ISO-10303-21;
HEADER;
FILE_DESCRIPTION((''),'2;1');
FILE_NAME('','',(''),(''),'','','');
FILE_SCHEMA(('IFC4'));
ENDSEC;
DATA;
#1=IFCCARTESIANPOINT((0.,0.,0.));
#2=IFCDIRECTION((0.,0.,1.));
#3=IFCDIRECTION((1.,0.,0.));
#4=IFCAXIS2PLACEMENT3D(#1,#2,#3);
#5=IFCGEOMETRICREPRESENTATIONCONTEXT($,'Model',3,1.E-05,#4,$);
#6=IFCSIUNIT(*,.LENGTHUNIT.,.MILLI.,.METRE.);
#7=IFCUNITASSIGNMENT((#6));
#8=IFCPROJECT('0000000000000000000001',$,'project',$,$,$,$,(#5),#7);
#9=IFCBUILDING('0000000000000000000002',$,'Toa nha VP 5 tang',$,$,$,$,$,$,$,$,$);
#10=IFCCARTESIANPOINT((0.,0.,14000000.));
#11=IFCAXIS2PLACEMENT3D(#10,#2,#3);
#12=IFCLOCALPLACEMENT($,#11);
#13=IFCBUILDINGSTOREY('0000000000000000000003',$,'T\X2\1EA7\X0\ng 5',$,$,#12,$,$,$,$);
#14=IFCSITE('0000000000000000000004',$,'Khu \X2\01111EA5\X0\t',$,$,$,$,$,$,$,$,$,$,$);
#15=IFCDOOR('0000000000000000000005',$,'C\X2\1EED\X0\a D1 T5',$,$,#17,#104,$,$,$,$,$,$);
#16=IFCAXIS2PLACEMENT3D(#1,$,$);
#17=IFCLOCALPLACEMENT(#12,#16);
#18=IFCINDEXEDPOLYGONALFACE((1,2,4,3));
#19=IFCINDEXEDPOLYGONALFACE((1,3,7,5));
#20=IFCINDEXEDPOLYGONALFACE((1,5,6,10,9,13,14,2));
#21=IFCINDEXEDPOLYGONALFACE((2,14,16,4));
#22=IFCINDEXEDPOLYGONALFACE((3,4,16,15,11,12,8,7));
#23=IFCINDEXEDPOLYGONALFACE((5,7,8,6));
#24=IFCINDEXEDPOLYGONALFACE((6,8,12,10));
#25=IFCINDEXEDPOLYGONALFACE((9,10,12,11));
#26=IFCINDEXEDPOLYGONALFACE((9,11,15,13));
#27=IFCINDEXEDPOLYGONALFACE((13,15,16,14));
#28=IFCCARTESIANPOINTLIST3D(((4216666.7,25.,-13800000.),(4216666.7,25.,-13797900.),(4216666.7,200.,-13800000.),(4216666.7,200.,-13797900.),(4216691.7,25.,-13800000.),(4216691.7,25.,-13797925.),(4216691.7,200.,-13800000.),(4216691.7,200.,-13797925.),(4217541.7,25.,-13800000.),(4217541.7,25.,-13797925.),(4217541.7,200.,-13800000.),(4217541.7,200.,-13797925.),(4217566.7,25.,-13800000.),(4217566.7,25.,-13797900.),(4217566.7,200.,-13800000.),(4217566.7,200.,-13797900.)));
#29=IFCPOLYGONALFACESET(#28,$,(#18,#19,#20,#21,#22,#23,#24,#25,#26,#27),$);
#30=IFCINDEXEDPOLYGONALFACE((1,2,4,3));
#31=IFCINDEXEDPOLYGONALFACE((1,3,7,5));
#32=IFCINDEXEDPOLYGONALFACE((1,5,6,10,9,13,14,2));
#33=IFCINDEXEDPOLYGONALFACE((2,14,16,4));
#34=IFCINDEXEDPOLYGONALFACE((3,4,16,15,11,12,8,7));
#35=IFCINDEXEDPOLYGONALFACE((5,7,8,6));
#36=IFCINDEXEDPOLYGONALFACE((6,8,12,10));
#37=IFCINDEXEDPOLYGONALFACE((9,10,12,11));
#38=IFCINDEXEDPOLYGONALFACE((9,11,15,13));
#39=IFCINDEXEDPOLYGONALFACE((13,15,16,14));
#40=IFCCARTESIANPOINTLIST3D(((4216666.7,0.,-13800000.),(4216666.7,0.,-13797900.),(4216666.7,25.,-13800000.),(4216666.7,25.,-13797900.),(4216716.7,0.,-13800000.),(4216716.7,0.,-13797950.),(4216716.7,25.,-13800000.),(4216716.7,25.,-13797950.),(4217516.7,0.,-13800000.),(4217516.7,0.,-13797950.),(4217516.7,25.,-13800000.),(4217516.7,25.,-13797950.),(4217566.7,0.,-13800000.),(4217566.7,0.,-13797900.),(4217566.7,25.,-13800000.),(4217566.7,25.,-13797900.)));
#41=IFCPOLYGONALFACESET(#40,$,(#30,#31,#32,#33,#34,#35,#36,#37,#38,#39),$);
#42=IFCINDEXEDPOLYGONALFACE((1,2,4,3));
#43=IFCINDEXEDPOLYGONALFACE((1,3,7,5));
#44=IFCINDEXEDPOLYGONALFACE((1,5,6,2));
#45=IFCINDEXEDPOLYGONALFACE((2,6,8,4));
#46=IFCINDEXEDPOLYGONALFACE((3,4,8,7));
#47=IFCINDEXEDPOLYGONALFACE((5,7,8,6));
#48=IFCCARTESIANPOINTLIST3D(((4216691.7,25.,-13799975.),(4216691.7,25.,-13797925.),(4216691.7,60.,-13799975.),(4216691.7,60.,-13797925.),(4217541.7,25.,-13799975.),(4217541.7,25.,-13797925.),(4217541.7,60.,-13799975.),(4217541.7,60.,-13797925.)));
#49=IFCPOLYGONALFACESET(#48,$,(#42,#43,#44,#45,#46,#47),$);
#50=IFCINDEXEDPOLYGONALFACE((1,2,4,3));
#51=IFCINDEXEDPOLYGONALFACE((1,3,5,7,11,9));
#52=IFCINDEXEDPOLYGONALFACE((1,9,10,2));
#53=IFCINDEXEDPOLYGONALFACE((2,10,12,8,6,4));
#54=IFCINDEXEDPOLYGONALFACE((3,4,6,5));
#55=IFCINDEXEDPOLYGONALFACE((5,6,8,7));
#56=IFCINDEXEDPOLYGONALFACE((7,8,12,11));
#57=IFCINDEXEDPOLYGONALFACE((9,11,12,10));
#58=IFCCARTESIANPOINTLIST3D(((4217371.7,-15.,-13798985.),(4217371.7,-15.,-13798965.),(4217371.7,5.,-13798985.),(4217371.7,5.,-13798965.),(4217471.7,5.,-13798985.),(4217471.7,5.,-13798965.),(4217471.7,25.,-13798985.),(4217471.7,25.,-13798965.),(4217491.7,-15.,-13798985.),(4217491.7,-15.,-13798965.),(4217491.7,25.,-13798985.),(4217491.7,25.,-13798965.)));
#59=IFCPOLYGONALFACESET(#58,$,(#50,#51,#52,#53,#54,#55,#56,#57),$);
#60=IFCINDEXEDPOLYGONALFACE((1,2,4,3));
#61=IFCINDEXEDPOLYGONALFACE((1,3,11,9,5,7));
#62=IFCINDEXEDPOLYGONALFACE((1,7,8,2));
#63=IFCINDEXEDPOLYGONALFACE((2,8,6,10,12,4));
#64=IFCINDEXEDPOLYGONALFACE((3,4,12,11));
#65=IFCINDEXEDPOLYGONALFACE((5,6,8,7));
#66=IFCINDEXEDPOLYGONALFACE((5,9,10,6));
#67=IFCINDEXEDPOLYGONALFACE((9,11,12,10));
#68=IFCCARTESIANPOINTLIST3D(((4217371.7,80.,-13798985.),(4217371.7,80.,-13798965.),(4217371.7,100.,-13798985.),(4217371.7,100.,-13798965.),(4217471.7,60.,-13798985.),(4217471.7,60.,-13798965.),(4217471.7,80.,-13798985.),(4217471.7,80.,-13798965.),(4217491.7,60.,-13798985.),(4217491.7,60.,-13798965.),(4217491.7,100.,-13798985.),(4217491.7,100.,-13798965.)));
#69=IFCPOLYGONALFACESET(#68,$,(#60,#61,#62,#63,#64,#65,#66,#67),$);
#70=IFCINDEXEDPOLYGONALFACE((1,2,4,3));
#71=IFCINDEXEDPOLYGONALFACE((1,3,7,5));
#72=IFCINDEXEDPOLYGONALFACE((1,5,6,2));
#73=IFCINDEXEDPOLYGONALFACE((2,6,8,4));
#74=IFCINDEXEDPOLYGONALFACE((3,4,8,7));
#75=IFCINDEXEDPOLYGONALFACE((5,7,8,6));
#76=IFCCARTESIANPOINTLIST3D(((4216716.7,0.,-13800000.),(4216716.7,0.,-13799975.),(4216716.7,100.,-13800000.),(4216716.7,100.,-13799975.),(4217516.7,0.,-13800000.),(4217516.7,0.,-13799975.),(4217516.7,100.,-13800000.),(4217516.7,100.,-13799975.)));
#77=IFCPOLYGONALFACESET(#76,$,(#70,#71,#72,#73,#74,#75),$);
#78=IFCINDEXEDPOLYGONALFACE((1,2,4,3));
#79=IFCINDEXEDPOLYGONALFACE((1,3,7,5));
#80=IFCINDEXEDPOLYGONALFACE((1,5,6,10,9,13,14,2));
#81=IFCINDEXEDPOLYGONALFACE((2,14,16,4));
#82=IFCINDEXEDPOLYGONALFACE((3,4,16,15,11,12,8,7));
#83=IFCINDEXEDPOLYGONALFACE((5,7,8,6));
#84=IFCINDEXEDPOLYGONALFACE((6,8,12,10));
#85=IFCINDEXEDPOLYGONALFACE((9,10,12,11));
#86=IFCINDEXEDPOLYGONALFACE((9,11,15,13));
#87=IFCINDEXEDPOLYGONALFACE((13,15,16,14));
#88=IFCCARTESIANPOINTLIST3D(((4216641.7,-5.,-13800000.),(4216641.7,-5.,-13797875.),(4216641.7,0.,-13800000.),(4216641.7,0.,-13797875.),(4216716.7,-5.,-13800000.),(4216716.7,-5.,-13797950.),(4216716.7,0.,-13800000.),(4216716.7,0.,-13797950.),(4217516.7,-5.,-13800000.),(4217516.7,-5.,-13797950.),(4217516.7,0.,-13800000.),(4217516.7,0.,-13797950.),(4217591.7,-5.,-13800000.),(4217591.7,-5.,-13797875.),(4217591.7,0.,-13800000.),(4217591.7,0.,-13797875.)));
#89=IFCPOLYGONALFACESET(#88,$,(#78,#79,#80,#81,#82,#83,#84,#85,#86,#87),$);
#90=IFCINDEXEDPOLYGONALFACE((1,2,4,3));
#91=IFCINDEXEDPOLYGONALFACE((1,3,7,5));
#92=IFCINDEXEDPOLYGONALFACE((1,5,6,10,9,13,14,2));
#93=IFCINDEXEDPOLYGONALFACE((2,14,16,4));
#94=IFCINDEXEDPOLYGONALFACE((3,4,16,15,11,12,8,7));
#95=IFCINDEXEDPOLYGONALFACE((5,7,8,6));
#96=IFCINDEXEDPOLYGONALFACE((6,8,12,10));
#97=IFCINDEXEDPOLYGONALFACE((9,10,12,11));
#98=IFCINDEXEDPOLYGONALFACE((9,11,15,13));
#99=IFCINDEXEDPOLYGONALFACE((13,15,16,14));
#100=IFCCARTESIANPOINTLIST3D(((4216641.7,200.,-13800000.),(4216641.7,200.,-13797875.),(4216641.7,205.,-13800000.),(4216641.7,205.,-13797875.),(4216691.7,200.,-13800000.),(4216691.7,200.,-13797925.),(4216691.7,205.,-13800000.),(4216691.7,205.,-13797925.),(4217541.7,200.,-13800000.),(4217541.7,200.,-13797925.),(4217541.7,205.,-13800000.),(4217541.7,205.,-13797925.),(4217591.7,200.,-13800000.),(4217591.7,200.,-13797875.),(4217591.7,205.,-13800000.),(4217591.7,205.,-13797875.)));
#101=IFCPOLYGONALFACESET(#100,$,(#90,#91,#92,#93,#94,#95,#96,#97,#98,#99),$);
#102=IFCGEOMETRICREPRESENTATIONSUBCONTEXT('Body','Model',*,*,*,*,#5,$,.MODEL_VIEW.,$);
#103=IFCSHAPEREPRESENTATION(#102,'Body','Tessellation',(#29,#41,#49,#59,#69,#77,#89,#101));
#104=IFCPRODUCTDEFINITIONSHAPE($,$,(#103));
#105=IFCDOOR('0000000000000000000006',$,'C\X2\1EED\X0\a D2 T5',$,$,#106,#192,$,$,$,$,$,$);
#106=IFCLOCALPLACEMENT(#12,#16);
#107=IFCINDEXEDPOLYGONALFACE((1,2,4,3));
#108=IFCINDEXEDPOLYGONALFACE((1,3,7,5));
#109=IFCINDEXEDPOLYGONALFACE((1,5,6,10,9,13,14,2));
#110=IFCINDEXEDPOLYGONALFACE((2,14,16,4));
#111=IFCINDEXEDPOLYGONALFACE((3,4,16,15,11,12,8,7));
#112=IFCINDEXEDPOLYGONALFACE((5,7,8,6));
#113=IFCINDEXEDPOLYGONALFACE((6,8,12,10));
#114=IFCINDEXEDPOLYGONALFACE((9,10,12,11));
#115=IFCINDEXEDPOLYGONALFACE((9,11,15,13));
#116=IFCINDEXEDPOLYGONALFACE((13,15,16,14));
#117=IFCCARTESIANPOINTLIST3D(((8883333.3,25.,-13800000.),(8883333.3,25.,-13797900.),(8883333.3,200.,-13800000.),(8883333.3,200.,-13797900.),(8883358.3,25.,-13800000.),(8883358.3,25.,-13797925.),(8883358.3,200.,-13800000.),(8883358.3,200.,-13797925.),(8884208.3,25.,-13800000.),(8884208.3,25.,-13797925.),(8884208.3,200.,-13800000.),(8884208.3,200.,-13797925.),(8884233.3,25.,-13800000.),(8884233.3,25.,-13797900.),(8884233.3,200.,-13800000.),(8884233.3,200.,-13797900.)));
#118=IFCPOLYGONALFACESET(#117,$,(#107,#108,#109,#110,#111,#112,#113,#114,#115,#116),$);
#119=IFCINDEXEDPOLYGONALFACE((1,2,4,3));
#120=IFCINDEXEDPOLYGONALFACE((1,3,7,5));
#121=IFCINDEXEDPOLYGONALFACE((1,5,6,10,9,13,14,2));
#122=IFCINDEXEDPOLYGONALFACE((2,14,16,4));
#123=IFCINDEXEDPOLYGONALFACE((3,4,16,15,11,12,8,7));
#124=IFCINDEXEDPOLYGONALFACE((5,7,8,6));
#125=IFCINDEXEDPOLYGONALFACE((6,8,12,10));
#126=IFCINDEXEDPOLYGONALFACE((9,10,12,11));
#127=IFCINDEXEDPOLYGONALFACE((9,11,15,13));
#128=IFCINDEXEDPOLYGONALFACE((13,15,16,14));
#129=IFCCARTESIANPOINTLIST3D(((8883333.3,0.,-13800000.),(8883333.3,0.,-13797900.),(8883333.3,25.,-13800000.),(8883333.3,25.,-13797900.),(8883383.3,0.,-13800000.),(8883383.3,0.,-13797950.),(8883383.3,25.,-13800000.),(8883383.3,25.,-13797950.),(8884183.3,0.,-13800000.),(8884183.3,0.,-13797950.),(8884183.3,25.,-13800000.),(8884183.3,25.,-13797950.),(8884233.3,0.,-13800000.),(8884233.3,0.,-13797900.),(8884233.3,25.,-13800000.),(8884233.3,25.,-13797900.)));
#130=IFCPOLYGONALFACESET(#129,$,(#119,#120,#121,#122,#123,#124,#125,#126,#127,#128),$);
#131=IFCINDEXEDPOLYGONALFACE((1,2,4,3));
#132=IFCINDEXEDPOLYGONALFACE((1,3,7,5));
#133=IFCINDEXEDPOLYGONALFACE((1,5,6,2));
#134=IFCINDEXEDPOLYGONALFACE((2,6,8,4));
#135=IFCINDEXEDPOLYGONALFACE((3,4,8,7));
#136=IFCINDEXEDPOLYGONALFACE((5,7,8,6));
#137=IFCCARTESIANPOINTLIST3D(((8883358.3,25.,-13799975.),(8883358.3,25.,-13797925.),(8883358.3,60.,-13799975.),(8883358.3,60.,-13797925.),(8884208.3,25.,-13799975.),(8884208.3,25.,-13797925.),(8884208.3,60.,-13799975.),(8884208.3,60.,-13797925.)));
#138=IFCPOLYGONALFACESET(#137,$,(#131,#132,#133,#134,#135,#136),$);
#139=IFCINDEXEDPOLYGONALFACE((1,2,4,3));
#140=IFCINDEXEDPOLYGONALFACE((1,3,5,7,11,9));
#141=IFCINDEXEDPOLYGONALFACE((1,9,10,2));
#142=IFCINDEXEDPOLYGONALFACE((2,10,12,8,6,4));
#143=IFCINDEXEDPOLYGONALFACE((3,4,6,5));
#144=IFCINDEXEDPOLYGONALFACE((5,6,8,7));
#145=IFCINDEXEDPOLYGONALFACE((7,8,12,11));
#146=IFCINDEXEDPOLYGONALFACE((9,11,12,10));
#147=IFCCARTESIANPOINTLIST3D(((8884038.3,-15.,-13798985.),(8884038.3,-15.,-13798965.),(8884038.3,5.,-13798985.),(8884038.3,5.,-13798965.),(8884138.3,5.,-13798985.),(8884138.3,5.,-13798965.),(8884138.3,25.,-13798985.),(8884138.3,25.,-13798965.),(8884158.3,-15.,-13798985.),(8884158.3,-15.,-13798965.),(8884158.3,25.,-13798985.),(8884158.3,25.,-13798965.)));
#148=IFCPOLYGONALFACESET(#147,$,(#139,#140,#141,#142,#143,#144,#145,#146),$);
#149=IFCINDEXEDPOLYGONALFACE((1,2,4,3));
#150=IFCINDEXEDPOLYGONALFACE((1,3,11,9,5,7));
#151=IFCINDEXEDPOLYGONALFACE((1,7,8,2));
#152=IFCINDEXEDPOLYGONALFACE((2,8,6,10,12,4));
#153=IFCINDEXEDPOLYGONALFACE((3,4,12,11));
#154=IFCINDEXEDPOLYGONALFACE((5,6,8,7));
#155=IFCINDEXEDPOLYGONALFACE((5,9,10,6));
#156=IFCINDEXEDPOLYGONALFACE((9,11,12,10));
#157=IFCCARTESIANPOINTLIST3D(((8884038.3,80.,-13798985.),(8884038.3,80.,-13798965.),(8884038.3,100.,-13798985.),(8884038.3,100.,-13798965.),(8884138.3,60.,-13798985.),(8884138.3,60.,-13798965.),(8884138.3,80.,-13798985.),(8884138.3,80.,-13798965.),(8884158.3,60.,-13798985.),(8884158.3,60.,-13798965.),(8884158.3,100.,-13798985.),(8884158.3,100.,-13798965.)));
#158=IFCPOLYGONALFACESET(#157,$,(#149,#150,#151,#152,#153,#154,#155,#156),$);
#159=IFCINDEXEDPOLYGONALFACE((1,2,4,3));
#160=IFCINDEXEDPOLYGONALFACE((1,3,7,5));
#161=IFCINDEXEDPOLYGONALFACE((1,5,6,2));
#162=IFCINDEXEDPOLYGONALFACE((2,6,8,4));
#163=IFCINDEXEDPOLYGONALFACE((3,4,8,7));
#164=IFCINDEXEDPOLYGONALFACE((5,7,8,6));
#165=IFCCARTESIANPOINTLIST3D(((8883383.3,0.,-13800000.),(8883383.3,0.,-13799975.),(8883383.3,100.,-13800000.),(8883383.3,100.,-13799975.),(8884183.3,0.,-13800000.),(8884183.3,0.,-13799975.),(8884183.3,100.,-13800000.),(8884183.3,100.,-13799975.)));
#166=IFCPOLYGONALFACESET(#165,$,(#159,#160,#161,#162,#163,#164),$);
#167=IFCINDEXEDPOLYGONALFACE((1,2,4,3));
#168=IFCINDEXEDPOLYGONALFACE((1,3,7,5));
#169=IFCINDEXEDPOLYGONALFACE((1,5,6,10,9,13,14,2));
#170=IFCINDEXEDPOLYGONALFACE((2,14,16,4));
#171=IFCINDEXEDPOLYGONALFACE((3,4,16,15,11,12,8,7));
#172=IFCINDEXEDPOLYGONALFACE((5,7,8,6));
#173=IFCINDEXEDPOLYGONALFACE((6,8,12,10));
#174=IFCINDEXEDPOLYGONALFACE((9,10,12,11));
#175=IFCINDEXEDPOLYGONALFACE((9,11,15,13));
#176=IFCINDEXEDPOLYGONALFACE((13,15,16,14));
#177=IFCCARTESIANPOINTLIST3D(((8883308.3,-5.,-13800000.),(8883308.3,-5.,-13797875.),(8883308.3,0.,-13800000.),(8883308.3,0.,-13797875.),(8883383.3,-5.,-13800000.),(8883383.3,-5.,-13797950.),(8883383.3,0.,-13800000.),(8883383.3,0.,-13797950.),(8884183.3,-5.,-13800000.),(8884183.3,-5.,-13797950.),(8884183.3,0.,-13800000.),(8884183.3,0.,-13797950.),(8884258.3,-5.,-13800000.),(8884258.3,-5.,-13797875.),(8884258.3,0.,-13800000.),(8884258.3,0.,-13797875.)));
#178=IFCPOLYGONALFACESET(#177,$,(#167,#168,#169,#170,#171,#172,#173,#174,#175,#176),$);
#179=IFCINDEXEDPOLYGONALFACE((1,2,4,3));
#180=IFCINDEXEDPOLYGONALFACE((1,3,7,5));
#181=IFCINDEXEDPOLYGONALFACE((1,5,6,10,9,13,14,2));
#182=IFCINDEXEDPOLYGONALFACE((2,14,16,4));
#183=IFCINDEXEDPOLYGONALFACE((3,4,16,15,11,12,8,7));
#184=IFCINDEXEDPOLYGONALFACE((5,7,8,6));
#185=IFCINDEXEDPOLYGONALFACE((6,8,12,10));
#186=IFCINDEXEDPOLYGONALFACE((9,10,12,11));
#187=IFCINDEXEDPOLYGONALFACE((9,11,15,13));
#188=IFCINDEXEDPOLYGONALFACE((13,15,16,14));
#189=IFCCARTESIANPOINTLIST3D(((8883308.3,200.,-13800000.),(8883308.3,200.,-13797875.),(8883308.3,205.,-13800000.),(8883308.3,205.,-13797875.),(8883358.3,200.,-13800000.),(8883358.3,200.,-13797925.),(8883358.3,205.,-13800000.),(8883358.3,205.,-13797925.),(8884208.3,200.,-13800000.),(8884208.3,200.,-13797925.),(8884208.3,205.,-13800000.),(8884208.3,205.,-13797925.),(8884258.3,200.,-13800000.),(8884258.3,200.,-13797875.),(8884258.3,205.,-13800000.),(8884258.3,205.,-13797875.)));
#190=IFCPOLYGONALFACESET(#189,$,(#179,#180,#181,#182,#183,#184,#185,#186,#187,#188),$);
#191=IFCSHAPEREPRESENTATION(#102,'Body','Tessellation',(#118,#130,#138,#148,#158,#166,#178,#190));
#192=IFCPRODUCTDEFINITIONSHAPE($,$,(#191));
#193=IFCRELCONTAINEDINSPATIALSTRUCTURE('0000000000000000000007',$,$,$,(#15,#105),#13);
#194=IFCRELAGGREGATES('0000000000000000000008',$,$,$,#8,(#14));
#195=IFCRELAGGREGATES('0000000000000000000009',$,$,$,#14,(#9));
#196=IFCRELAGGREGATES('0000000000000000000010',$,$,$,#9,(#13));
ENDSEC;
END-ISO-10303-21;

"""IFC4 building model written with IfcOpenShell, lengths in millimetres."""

from ifc_helpers import new_model, si_unit, frame, origin_with_axes, place, context, subcontext, project, spatial, line, indexed_curve, outline, extrude, element, save


model = new_model("IFC4")

# Units and contexts
model_context = context("Model", 3, precision=1e-05, world=origin_with_axes())
body_context = subcontext(model_context, "Body", "Model", "MODEL_VIEW")
ifc_project = project(units=[si_unit("LENGTHUNIT", "METRE", prefix="MILLI")], contexts=[model_context])

# Site, building, storey
site = spatial("IfcSite", under=ifc_project, Name="Khu đất")
building = spatial("IfcBuilding", under=site, Name="Toa nha VP 5 tang")
storey_placement = place(None, frame((0.0, 0.0, 14000000.0), z_axis=(0.0, 0.0, 1.0), x_axis=(1.0, 0.0, 0.0)))
storey = spatial("IfcBuildingStorey", under=building, at=storey_placement, Name="Tầng 5")

# Doors
door_1_placement = place(storey_placement, frame((4216666.7, 0.0, -13800000.0), z_axis=(0.0, 0.0, 1.0), x_axis=(1.0, 0.0, 0.0)))
element("IfcDoor", 1, at=door_1_placement, inside=storey, Name="Cửa D1 T5", context=body_context, shape_type="SolidModel", body=[
    extrude(outline(indexed_curve([(0.0, 0.0), (0.0, 2100.0), (900.0, 2100.0), (900.0, 0.0), (875.0, 0.0), (875.0, 2075.0), (25.0, 2075.0), (25.0, 0.0)], segments=[line(1, 2, 3, 4, 5, 6, 7, 8, 1)])), frame((0.0, 25.0, 0.0), z_axis=(0.0, -1.0, 0.0), x_axis=(1.0, 0.0, 0.0)), (0.0, 0.0, -1.0), 175.0),
    extrude(outline(indexed_curve([(0.0, 0.0), (0.0, 2100.0), (900.0, 2100.0), (900.0, 0.0), (850.0, 0.0), (850.0, 2050.0), (50.0, 2050.0), (50.0, 0.0)], segments=[line(1, 2, 3, 4, 5, 6, 7, 8, 1)])), frame((0.0, 0.0, 0.0), z_axis=(0.0, -1.0, 0.0), x_axis=(1.0, 0.0, 0.0)), (0.0, 0.0, -1.0), 25.0),
    extrude(outline(indexed_curve([(0.0, 0.0), (850.0, 0.0), (850.0, 35.0), (0.0, 35.0)], segments=[line(1, 2, 3, 4, 1)])), frame((25.0, 25.0, 25.0), z_axis=(0.0, 0.0, 1.0), x_axis=(1.0, 0.0, 0.0)), (0.0, 0.0, 1.0), 2050.0),
    extrude(outline(indexed_curve([(0.0, 0.0), (0.0, -40.0), (-120.0, -40.0), (-120.0, -20.0), (-20.0, -20.0), (-20.0, 0.0)], segments=[line(1, 2, 3, 4, 5, 6, 1)])), frame((825.0, 25.0, 1015.0), z_axis=(0.0, 0.0, 1.0), x_axis=(1.0, 0.0, 0.0)), (0.0, 0.0, 1.0), 20.0),
    extrude(outline(indexed_curve([(0.0, 0.0), (0.0, 40.0), (-120.0, 40.0), (-120.0, 20.0), (-20.0, 20.0), (-20.0, 0.0)], segments=[line(1, 2, 3, 4, 5, 6, 1)])), frame((825.0, 60.0, 1015.0), z_axis=(0.0, 0.0, 1.0), x_axis=(1.0, 0.0, 0.0)), (0.0, 0.0, 1.0), 20.0),
    extrude(outline(indexed_curve([(0.0, 0.0), (800.0, 0.0), (800.0, 100.0), (0.0, 100.0)], segments=[line(1, 2, 3, 4, 1)])), frame((50.0, 0.0, 0.0), z_axis=(0.0, 0.0, 1.0), x_axis=(1.0, 0.0, 0.0)), (0.0, 0.0, 1.0), 25.0),
    extrude(outline(indexed_curve([(0.0, 0.0), (0.0, 2125.0), (950.0, 2125.0), (950.0, 0.0), (875.0, 0.0), (875.0, 2050.0), (75.0, 2050.0), (75.0, 0.0)], segments=[line(1, 2, 3, 4, 5, 6, 7, 8, 1)])), frame((-25.0, -5.0, 0.0), z_axis=(0.0, -1.0, 0.0), x_axis=(1.0, 0.0, 0.0)), (0.0, 0.0, -1.0), 5.0),
    extrude(outline(indexed_curve([(0.0, 0.0), (0.0, 2125.0), (950.0, 2125.0), (950.0, 0.0), (900.0, 0.0), (900.0, 2075.0), (50.0, 2075.0), (50.0, 0.0)], segments=[line(1, 2, 3, 4, 5, 6, 7, 8, 1)])), frame((-25.0, 200.0, 0.0), z_axis=(0.0, -1.0, 0.0), x_axis=(1.0, 0.0, 0.0)), (0.0, 0.0, -1.0), 5.0),
])
door_2_placement = place(storey_placement, frame((8883333.3, 0.0, -13800000.0), z_axis=(0.0, 0.0, 1.0), x_axis=(1.0, 0.0, 0.0)))
element("IfcDoor", 2, at=door_2_placement, inside=storey, Name="Cửa D2 T5", context=body_context, shape_type="SolidModel", body=[
    extrude(outline(indexed_curve([(0.0, 0.0), (0.0, 2100.0), (900.0, 2100.0), (900.0, 0.0), (875.0, 0.0), (875.0, 2075.0), (25.0, 2075.0), (25.0, 0.0)], segments=[line(1, 2, 3, 4, 5, 6, 7, 8, 1)])), frame((0.0, 25.0, 0.0), z_axis=(0.0, -1.0, 0.0), x_axis=(1.0, 0.0, 0.0)), (0.0, 0.0, -1.0), 175.0),
    extrude(outline(indexed_curve([(0.0, 0.0), (0.0, 2100.0), (900.0, 2100.0), (900.0, 0.0), (850.0, 0.0), (850.0, 2050.0), (50.0, 2050.0), (50.0, 0.0)], segments=[line(1, 2, 3, 4, 5, 6, 7, 8, 1)])), frame((0.0, 0.0, 0.0), z_axis=(0.0, -1.0, 0.0), x_axis=(1.0, 0.0, 0.0)), (0.0, 0.0, -1.0), 25.0),
    extrude(outline(indexed_curve([(0.0, 0.0), (850.0, 0.0), (850.0, 35.0), (0.0, 35.0)], segments=[line(1, 2, 3, 4, 1)])), frame((25.0, 25.0, 25.0), z_axis=(0.0, 0.0, 1.0), x_axis=(1.0, 0.0, 0.0)), (0.0, 0.0, 1.0), 2050.0),
    extrude(outline(indexed_curve([(0.0, 0.0), (0.0, -40.0), (-120.0, -40.0), (-120.0, -20.0), (-20.0, -20.0), (-20.0, 0.0)], segments=[line(1, 2, 3, 4, 5, 6, 1)])), frame((825.0, 25.0, 1015.0), z_axis=(0.0, 0.0, 1.0), x_axis=(1.0, 0.0, 0.0)), (0.0, 0.0, 1.0), 20.0),
    extrude(outline(indexed_curve([(0.0, 0.0), (0.0, 40.0), (-120.0, 40.0), (-120.0, 20.0), (-20.0, 20.0), (-20.0, 0.0)], segments=[line(1, 2, 3, 4, 5, 6, 1)])), frame((825.0, 60.0, 1015.0), z_axis=(0.0, 0.0, 1.0), x_axis=(1.0, 0.0, 0.0)), (0.0, 0.0, 1.0), 20.0),
    extrude(outline(indexed_curve([(0.0, 0.0), (800.0, 0.0), (800.0, 100.0), (0.0, 100.0)], segments=[line(1, 2, 3, 4, 1)])), frame((50.0, 0.0, 0.0), z_axis=(0.0, 0.0, 1.0), x_axis=(1.0, 0.0, 0.0)), (0.0, 0.0, 1.0), 25.0),
    extrude(outline(indexed_curve([(0.0, 0.0), (0.0, 2125.0), (950.0, 2125.0), (950.0, 0.0), (875.0, 0.0), (875.0, 2050.0), (75.0, 2050.0), (75.0, 0.0)], segments=[line(1, 2, 3, 4, 5, 6, 7, 8, 1)])), frame((-25.0, -5.0, 0.0), z_axis=(0.0, -1.0, 0.0), x_axis=(1.0, 0.0, 0.0)), (0.0, 0.0, -1.0), 5.0),
    extrude(outline(indexed_curve([(0.0, 0.0), (0.0, 2125.0), (950.0, 2125.0), (950.0, 0.0), (900.0, 0.0), (900.0, 2075.0), (50.0, 2075.0), (50.0, 0.0)], segments=[line(1, 2, 3, 4, 5, 6, 7, 8, 1)])), frame((-25.0, 200.0, 0.0), z_axis=(0.0, -1.0, 0.0), x_axis=(1.0, 0.0, 0.0)), (0.0, 0.0, -1.0), 5.0),
])

save(model, "model.ifc")
